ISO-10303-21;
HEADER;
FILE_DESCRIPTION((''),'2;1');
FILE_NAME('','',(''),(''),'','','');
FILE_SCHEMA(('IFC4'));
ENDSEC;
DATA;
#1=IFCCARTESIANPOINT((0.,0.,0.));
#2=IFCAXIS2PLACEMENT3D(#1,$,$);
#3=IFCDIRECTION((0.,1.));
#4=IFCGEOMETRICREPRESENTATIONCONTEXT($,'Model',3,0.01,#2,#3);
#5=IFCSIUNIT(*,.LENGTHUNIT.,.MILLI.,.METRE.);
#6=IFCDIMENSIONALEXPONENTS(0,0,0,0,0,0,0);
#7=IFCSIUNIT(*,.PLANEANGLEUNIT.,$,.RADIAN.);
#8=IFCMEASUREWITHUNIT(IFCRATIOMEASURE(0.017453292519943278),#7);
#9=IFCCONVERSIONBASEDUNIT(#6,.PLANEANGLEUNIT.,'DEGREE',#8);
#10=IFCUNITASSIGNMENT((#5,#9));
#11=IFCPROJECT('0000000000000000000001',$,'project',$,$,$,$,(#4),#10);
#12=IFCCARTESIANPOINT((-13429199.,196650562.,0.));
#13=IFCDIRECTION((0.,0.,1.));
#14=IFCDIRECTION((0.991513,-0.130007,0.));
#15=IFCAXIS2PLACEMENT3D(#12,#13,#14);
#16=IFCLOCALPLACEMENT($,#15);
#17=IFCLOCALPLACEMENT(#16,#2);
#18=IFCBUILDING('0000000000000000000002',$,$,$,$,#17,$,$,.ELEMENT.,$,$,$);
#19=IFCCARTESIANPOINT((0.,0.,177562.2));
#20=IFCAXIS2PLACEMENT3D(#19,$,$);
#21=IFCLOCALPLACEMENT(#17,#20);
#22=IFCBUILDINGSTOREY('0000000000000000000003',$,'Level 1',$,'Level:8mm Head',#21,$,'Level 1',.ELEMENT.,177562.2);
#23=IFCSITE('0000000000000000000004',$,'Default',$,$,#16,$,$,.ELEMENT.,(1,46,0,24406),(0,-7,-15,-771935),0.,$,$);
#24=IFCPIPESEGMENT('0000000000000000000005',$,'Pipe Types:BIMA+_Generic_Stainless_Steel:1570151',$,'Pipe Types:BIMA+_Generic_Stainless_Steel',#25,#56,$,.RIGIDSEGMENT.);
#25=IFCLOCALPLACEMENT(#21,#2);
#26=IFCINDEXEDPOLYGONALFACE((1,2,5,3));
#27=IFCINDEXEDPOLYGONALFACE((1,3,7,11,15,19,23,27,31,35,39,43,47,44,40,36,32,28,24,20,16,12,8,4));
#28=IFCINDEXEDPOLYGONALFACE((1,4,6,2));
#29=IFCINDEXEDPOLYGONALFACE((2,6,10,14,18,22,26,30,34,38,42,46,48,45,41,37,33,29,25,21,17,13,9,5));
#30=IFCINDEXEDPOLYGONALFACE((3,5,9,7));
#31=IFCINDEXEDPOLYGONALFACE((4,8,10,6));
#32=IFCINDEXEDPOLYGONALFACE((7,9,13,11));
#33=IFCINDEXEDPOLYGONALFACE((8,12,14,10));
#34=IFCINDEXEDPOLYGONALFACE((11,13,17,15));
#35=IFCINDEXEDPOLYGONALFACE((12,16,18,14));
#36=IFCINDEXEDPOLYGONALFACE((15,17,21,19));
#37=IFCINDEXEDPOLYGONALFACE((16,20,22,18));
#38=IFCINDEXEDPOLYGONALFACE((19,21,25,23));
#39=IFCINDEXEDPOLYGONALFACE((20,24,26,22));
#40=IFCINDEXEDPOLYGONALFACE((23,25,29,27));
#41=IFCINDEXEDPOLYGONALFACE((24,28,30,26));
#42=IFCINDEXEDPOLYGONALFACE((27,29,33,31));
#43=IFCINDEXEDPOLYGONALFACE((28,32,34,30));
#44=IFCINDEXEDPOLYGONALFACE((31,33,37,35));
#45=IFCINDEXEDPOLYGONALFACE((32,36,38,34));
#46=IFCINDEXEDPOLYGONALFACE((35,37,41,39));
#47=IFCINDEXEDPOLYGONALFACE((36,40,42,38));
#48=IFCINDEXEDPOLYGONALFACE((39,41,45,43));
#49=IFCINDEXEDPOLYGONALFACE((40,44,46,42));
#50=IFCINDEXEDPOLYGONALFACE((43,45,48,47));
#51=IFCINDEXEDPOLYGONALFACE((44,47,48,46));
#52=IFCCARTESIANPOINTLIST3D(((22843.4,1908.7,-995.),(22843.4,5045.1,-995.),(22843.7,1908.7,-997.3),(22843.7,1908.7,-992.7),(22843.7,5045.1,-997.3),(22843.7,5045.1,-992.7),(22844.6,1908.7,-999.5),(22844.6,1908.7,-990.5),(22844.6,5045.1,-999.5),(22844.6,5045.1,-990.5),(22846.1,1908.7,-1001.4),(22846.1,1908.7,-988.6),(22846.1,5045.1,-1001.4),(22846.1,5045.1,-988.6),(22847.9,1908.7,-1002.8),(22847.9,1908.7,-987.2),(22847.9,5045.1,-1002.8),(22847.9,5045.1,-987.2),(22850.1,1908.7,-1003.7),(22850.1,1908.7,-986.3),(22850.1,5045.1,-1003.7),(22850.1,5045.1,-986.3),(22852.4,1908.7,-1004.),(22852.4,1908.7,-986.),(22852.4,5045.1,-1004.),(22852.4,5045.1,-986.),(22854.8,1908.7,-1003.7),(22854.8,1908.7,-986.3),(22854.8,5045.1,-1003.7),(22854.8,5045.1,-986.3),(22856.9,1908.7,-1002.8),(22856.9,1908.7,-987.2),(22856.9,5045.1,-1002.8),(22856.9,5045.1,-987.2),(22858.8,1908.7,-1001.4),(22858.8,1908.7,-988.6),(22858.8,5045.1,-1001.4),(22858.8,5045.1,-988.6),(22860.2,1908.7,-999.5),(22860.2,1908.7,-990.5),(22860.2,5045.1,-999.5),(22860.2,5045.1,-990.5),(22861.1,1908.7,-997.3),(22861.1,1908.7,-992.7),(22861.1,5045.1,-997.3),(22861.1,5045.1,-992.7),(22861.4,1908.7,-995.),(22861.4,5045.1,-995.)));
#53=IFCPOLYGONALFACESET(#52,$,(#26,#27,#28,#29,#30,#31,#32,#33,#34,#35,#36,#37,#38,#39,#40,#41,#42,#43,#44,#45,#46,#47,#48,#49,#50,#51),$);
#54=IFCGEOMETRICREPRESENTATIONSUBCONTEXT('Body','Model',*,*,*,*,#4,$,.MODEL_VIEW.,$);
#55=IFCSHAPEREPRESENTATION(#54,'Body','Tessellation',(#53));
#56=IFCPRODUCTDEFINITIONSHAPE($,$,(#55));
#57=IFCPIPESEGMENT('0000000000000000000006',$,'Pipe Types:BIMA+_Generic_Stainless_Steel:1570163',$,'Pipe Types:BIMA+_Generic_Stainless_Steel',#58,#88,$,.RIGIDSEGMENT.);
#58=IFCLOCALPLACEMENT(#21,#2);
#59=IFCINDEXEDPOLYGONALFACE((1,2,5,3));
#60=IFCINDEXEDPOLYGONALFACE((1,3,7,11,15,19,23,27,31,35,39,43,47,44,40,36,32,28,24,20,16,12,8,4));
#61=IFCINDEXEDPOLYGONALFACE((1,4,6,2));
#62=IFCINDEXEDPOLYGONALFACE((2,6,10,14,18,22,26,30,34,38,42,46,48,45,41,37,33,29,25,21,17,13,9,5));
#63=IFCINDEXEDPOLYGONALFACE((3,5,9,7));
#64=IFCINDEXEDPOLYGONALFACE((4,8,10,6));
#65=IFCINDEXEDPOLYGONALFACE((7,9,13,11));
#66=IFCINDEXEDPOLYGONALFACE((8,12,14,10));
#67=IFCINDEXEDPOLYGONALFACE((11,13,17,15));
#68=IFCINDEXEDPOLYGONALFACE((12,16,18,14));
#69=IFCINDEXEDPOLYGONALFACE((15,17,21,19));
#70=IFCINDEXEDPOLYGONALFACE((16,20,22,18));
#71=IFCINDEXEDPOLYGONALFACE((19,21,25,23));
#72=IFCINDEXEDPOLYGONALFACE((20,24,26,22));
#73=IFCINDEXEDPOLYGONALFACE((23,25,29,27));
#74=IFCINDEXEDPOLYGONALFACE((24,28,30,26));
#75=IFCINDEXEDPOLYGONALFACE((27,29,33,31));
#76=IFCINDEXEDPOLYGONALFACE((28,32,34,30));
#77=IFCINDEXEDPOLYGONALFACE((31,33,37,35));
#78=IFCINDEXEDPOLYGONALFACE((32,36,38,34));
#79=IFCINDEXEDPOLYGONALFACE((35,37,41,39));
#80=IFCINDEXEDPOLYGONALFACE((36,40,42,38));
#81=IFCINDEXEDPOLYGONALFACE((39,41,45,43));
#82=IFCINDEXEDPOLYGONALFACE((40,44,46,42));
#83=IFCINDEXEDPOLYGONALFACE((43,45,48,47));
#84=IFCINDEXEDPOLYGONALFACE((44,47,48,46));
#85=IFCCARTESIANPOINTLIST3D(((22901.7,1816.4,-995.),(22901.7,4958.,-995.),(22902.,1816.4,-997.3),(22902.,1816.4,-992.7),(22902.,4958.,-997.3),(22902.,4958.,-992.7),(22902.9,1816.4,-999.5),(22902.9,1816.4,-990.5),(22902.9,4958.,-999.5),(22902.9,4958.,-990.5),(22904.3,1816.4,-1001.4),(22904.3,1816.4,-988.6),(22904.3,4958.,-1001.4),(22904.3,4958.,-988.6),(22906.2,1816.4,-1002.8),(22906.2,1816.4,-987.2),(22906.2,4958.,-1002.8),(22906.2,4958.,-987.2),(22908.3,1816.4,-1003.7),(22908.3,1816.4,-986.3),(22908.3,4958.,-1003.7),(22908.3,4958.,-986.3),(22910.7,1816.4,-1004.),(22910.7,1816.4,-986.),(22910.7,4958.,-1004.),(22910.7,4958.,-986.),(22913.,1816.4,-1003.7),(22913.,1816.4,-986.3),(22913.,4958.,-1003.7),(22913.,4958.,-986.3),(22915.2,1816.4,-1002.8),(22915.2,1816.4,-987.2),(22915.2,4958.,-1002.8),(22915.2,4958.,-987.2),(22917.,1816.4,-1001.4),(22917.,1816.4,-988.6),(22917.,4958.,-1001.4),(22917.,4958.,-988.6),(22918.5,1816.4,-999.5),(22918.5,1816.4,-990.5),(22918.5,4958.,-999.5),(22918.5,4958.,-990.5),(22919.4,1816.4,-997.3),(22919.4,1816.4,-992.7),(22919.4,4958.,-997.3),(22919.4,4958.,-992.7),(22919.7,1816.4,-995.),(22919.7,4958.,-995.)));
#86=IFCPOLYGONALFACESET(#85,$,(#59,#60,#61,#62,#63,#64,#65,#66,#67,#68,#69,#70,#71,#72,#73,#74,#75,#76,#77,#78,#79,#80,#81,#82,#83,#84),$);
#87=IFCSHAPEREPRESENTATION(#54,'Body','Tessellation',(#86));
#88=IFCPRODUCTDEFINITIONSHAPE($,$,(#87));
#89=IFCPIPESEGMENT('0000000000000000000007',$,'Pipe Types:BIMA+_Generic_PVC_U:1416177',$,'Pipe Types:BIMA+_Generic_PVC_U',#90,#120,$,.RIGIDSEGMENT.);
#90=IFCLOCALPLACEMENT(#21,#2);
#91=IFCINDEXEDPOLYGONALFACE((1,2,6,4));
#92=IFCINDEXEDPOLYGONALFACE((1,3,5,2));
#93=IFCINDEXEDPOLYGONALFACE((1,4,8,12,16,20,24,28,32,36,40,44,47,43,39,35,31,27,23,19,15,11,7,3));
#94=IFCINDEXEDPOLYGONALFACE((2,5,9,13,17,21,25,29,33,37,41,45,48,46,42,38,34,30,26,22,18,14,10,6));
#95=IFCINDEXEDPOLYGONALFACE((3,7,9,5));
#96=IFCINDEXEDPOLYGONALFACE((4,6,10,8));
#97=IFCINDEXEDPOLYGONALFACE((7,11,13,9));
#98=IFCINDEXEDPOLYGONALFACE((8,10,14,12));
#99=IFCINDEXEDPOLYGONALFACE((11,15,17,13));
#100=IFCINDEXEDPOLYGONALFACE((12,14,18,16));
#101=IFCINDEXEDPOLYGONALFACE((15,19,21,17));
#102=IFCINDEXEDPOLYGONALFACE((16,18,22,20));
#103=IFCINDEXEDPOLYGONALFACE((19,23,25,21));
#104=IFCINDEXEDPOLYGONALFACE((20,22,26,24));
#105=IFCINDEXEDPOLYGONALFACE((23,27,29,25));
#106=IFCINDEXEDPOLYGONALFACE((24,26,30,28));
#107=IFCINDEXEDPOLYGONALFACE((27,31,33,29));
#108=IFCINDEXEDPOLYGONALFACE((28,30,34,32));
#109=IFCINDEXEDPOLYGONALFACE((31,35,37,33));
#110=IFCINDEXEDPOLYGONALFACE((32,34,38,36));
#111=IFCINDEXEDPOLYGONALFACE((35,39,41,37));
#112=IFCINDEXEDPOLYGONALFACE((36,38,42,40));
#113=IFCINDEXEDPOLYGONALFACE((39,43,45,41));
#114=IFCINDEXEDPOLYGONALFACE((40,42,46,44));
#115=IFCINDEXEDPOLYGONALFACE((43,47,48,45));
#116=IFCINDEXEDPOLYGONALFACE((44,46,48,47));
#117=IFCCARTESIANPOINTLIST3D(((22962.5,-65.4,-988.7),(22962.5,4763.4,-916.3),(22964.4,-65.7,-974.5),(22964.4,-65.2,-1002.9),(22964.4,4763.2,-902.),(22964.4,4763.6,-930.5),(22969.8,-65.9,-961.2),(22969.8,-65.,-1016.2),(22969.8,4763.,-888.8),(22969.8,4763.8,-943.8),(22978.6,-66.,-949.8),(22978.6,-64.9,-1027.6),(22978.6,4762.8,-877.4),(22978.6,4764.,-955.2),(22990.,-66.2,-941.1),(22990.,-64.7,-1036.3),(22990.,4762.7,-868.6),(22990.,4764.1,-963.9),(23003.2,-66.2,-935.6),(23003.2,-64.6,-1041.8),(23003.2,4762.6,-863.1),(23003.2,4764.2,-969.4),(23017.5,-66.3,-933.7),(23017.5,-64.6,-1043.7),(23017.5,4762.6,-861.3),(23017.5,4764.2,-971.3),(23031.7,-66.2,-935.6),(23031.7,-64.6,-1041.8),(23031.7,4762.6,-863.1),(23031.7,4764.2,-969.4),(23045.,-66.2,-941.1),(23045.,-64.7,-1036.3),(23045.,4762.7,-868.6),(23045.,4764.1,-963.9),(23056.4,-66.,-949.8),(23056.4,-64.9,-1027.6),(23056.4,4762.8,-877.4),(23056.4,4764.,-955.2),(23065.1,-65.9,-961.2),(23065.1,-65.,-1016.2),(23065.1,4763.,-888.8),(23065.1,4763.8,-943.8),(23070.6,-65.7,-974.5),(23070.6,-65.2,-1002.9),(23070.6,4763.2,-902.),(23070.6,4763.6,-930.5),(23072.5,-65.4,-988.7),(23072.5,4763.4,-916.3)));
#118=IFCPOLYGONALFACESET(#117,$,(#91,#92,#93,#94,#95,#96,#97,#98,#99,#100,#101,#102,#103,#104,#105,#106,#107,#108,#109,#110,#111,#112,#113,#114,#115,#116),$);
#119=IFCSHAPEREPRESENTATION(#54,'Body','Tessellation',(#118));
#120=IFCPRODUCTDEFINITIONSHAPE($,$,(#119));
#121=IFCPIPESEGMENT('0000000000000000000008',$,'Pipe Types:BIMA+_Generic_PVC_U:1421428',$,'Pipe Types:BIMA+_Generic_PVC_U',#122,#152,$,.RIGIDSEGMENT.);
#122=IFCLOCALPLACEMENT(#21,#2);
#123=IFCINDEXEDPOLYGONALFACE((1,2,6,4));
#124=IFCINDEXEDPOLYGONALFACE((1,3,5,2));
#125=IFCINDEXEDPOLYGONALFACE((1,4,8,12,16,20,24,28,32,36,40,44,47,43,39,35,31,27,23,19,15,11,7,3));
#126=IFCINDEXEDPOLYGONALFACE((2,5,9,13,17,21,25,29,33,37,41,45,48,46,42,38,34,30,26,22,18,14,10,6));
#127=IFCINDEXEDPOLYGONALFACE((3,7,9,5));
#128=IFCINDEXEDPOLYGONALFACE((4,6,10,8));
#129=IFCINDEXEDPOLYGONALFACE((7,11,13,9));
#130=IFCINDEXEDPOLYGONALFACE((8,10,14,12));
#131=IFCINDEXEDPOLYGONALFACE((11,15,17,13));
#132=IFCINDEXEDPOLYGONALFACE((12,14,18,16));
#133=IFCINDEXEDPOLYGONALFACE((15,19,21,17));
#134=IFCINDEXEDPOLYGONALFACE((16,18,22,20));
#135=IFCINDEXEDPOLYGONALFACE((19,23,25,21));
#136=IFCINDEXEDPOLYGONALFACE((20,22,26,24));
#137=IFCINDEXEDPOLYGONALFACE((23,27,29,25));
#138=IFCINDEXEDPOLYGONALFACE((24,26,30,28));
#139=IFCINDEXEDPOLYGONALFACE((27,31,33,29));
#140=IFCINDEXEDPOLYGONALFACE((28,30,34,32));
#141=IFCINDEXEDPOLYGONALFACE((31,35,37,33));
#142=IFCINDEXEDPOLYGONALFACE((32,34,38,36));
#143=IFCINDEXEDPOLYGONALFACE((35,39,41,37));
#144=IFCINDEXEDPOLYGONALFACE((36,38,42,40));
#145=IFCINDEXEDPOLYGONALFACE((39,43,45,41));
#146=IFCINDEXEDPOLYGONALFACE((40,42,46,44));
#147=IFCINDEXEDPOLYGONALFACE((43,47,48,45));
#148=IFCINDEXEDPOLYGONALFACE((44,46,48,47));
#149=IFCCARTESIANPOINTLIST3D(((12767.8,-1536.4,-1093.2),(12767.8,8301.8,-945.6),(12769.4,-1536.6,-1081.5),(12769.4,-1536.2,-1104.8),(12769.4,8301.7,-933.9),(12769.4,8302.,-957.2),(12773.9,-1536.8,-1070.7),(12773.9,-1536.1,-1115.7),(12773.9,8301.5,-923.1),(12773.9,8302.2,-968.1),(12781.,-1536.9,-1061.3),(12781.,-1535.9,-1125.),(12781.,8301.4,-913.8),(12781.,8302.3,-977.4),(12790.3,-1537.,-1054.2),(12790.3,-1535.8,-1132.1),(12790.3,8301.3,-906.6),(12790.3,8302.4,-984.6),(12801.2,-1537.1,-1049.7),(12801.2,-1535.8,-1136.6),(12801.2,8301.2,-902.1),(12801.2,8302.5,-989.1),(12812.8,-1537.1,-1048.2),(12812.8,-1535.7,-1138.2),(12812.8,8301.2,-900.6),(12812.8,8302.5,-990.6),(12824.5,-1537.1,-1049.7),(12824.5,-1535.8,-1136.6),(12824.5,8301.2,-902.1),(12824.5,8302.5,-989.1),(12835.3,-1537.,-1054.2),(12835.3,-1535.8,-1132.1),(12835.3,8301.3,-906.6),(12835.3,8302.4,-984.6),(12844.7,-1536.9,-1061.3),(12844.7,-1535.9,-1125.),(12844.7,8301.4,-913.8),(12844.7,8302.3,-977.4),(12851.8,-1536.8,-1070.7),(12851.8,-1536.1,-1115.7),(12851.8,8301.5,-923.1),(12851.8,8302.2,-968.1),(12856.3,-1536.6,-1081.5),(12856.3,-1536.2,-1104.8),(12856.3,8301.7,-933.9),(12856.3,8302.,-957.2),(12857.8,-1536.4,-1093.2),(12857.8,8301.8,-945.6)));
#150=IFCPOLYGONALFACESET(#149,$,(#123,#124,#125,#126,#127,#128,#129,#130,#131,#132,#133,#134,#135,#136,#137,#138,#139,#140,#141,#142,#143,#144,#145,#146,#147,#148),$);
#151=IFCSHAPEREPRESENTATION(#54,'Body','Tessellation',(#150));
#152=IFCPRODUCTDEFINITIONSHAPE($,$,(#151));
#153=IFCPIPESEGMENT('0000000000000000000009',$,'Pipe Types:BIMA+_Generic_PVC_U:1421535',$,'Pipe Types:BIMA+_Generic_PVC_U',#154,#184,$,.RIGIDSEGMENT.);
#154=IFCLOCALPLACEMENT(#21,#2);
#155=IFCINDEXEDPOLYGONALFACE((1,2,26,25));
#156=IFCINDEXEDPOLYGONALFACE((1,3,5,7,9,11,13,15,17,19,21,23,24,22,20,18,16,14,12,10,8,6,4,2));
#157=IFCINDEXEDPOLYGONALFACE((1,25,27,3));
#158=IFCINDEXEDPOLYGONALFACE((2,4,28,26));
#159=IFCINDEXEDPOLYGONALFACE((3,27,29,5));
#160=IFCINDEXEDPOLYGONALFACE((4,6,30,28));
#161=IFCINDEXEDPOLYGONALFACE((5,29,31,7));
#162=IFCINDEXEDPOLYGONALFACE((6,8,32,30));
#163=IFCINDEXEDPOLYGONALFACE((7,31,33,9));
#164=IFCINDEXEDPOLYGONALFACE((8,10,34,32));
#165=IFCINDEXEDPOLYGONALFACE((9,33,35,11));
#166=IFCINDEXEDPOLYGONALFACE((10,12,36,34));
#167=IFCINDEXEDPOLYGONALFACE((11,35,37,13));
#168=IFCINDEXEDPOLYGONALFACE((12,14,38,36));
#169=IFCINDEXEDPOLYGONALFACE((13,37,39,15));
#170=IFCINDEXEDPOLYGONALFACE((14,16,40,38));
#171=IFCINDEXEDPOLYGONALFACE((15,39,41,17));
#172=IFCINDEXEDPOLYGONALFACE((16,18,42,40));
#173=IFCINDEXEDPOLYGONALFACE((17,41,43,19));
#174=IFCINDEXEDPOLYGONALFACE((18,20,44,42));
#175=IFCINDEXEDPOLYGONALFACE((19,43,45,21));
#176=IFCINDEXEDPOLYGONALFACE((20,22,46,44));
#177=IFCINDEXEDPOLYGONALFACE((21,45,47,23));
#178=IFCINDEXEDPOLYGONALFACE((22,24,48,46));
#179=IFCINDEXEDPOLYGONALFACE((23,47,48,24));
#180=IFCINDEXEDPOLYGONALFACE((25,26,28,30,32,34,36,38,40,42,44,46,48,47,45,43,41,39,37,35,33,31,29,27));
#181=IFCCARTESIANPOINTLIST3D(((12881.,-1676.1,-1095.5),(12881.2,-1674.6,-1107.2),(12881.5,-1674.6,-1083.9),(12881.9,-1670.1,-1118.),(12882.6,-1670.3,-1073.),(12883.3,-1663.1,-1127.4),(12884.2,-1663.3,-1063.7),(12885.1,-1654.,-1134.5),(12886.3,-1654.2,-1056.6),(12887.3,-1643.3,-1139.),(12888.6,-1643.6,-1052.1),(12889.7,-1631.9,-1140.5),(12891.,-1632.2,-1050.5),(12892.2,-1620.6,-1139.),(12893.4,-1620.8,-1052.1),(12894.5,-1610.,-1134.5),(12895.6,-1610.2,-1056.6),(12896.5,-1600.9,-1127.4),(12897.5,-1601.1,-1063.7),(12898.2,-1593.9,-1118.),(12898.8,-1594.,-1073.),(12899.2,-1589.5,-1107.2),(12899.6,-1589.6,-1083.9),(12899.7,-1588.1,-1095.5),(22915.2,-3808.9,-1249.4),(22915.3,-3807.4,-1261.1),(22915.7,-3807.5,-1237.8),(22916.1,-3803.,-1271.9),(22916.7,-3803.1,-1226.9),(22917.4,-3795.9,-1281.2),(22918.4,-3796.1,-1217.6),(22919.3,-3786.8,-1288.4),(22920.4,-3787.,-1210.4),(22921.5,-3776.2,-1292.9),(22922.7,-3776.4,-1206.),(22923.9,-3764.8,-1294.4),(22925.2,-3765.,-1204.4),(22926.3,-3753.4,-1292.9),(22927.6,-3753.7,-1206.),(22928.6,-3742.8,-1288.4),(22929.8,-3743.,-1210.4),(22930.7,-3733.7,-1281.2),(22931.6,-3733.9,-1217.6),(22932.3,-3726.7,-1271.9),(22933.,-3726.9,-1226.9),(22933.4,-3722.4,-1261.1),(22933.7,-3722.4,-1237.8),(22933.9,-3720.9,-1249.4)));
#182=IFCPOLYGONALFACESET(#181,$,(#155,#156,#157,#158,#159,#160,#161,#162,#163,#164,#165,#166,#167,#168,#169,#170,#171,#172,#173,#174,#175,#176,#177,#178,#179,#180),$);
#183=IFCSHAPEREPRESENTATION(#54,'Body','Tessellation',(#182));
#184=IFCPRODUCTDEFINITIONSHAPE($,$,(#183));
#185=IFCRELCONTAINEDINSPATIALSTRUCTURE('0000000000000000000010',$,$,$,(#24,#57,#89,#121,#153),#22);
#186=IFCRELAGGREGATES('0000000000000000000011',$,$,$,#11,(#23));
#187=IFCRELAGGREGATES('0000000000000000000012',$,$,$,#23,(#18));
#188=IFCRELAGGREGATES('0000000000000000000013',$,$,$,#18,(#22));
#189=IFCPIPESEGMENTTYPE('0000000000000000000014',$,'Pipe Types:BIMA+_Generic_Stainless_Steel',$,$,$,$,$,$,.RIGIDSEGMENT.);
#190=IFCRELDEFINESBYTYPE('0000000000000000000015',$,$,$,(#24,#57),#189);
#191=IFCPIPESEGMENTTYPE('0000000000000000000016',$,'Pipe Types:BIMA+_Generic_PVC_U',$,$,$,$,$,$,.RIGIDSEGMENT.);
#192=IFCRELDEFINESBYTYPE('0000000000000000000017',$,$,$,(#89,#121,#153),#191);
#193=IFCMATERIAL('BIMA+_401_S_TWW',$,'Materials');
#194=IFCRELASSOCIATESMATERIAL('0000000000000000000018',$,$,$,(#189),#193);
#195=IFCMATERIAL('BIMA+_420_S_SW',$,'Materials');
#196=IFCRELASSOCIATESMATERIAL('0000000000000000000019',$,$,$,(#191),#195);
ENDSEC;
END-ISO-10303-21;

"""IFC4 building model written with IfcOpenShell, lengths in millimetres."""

from ifc_helpers import new_model, entity, si_unit, converted_unit, direction, frame, origin, place, context, subcontext, project, spatial, arc, indexed_curve, outline, extrude, material, type_object, element, save


model = new_model("IFC4")

# Units and contexts
model_context = context("Model", 3, precision=0.01, world=origin(), true_north=direction((0.0, 1.0)))
body_context = subcontext(model_context, "Body", "Model", "MODEL_VIEW")
ifc_project = project(units=[si_unit("LENGTHUNIT", "METRE", prefix="MILLI"), converted_unit("PLANEANGLEUNIT", "DEGREE", entity("IfcRatioMeasure", 0.017453292519943278), si_unit("PLANEANGLEUNIT", "RADIAN"), dimensions=[0, 0, 0, 0, 0, 0, 0])], contexts=[model_context])

# Site, building, storey
site_placement = place(None, frame((-13429199.0, 196650562.0, 0.0), z_axis=(0.0, 0.0, 1.0), x_axis=(0.991513, -0.130007, 0.0)))
site = spatial("IfcSite", under=ifc_project, at=site_placement, Name="Default", CompositionType="ELEMENT", RefLatitude=(1, 46, 0, 24406), RefLongitude=(0, -7, -15, -771935), RefElevation=0.0)
building_placement = place(site_placement, origin())
building = spatial("IfcBuilding", under=site, at=building_placement, CompositionType="ELEMENT")
storey_placement = place(building_placement, frame((0.0, 0.0, 177562.2)))
storey = spatial("IfcBuildingStorey", under=building, at=storey_placement, Name="Level 1", ObjectType="Level:8mm Head", LongName="Level 1", CompositionType="ELEMENT", Elevation=177562.2)

# Pipe segments
ifc_material_1 = material(Name="BIMA+_401_S_TWW", Category="Materials")
pipe_segment_type_1 = type_object("IfcPipeSegmentType", Name="Pipe Types:BIMA+_Generic_Stainless_Steel", PredefinedType="RIGIDSEGMENT", material=ifc_material_1)
pipe_segment_1_placement = place(storey_placement, frame((22841.8, 1908.7, -1005.6)))
element("IfcPipeSegment", 1, at=pipe_segment_1_placement, inside=storey, type_object=pipe_segment_type_1, Name="Pipe Types:BIMA+_Generic_Stainless_Steel:1570151", ObjectType="Pipe Types:BIMA+_Generic_Stainless_Steel", PredefinedType="RIGIDSEGMENT", context=body_context, shape_type="SweptSolid", body=[
    extrude(outline(indexed_curve([(9.0, 0.0), (6.4, 6.4), (0.0, 9.0), (-6.4, 6.4), (-9.0, 0.0), (-6.4, -6.4), (0.0, -9.0), (6.4, -6.4)], segments=[arc(1, 2, 3), arc(3, 4, 5), arc(5, 6, 7), arc(7, 8, 1)], self_intersect=False)), frame((10.6, 0.0, 10.6), z_axis=(0.0, 1.0, 0.0), x_axis=(1.0, 0.0, 0.0)), (0.0, 0.0, 1.0), 3136.4),
])
pipe_segment_2_placement = place(storey_placement, frame((22900.1, 1816.4, -1005.6)))
element("IfcPipeSegment", 2, at=pipe_segment_2_placement, inside=storey, type_object=pipe_segment_type_1, Name="Pipe Types:BIMA+_Generic_Stainless_Steel:1570163", ObjectType="Pipe Types:BIMA+_Generic_Stainless_Steel", PredefinedType="RIGIDSEGMENT", context=body_context, shape_type="SweptSolid", body=[
    extrude(outline(indexed_curve([(9.0, 0.0), (6.4, 6.4), (0.0, 9.0), (-6.4, 6.4), (-9.0, 0.0), (-6.4, -6.4), (0.0, -9.0), (6.4, -6.4)], segments=[arc(1, 2, 3), arc(3, 4, 5), arc(5, 6, 7), arc(7, 8, 1)], self_intersect=False)), frame((10.6, 0.0, 10.6), z_axis=(0.0, 1.0, 0.0), x_axis=(1.0, 0.0, 0.0)), (0.0, 0.0, 1.0), 3141.6),
])
ifc_material_2 = material(Name="BIMA+_420_S_SW", Category="Materials")
pipe_segment_type_2 = type_object("IfcPipeSegmentType", Name="Pipe Types:BIMA+_Generic_PVC_U", PredefinedType="RIGIDSEGMENT", material=ifc_material_2)
pipe_segment_3_placement = place(storey_placement, frame((22960.9, -67.9, -1045.3)))
element("IfcPipeSegment", 3, at=pipe_segment_3_placement, inside=storey, type_object=pipe_segment_type_2, Name="Pipe Types:BIMA+_Generic_PVC_U:1416177", ObjectType="Pipe Types:BIMA+_Generic_PVC_U", PredefinedType="RIGIDSEGMENT", context=body_context, shape_type="SweptSolid", body=[
    extrude(outline(indexed_curve([(55.0, 0.0), (38.9, 38.9), (0.0, 55.0), (-38.9, 38.9), (-55.0, 0.0), (-38.9, -38.9), (0.0, -55.0), (38.9, -38.9)], segments=[arc(1, 2, 3), arc(3, 4, 5), arc(5, 6, 7), arc(7, 8, 1)], self_intersect=False)), frame((56.6, 2.4, 56.6), z_axis=(0.0, 0.999888, 0.014998), x_axis=(-1.0, 0.0, 0.0)), (0.0, 0.0, 1.0), 4829.4),
])
pipe_segment_4_placement = place(storey_placement, frame((12766.2, -1538.7, -1139.8)))
element("IfcPipeSegment", 4, at=pipe_segment_4_placement, inside=storey, type_object=pipe_segment_type_2, Name="Pipe Types:BIMA+_Generic_PVC_U:1421428", ObjectType="Pipe Types:BIMA+_Generic_PVC_U", PredefinedType="RIGIDSEGMENT", context=body_context, shape_type="SweptSolid", body=[
    extrude(outline(indexed_curve([(45.0, 0.0), (31.8, 31.8), (0.0, 45.0), (-31.8, 31.8), (-45.0, 0.0), (-31.8, -31.8), (0.0, -45.0), (31.8, -31.8)], segments=[arc(1, 2, 3), arc(3, 4, 5), arc(5, 6, 7), arc(7, 8, 1)], self_intersect=False)), frame((46.6, 2.3, 46.6), z_axis=(0.0, 0.999888, 0.014998), x_axis=(-1.0, 0.0, 0.0)), (0.0, 0.0, 1.0), 9839.4),
])
pipe_segment_5_placement = place(storey_placement, frame((12879.4, -3810.5, -1048.9)))
element("IfcPipeSegment", 5, at=pipe_segment_5_placement, inside=storey, type_object=pipe_segment_type_2, Name="Pipe Types:BIMA+_Generic_PVC_U:1421535", ObjectType="Pipe Types:BIMA+_Generic_PVC_U", PredefinedType="RIGIDSEGMENT", context=body_context, shape_type="SweptSolid", body=[
    extrude(outline(indexed_curve([(45.0, 0.0), (31.8, 31.8), (0.0, 45.0), (-31.8, 31.8), (-45.0, 0.0), (-31.8, -31.8), (0.0, -45.0), (31.8, -31.8)], segments=[arc(1, 2, 3), arc(3, 4, 5), arc(5, 6, 7), arc(7, 8, 1)], self_intersect=False)), frame((10045.1, 45.6, -200.5), z_axis=(-0.978038, 0.207888, 0.014998), x_axis=(-0.207912, -0.978148, 0.0)), (0.0, 0.0, 1.0), 10259.5),
])

save(model, "model.ifc")
